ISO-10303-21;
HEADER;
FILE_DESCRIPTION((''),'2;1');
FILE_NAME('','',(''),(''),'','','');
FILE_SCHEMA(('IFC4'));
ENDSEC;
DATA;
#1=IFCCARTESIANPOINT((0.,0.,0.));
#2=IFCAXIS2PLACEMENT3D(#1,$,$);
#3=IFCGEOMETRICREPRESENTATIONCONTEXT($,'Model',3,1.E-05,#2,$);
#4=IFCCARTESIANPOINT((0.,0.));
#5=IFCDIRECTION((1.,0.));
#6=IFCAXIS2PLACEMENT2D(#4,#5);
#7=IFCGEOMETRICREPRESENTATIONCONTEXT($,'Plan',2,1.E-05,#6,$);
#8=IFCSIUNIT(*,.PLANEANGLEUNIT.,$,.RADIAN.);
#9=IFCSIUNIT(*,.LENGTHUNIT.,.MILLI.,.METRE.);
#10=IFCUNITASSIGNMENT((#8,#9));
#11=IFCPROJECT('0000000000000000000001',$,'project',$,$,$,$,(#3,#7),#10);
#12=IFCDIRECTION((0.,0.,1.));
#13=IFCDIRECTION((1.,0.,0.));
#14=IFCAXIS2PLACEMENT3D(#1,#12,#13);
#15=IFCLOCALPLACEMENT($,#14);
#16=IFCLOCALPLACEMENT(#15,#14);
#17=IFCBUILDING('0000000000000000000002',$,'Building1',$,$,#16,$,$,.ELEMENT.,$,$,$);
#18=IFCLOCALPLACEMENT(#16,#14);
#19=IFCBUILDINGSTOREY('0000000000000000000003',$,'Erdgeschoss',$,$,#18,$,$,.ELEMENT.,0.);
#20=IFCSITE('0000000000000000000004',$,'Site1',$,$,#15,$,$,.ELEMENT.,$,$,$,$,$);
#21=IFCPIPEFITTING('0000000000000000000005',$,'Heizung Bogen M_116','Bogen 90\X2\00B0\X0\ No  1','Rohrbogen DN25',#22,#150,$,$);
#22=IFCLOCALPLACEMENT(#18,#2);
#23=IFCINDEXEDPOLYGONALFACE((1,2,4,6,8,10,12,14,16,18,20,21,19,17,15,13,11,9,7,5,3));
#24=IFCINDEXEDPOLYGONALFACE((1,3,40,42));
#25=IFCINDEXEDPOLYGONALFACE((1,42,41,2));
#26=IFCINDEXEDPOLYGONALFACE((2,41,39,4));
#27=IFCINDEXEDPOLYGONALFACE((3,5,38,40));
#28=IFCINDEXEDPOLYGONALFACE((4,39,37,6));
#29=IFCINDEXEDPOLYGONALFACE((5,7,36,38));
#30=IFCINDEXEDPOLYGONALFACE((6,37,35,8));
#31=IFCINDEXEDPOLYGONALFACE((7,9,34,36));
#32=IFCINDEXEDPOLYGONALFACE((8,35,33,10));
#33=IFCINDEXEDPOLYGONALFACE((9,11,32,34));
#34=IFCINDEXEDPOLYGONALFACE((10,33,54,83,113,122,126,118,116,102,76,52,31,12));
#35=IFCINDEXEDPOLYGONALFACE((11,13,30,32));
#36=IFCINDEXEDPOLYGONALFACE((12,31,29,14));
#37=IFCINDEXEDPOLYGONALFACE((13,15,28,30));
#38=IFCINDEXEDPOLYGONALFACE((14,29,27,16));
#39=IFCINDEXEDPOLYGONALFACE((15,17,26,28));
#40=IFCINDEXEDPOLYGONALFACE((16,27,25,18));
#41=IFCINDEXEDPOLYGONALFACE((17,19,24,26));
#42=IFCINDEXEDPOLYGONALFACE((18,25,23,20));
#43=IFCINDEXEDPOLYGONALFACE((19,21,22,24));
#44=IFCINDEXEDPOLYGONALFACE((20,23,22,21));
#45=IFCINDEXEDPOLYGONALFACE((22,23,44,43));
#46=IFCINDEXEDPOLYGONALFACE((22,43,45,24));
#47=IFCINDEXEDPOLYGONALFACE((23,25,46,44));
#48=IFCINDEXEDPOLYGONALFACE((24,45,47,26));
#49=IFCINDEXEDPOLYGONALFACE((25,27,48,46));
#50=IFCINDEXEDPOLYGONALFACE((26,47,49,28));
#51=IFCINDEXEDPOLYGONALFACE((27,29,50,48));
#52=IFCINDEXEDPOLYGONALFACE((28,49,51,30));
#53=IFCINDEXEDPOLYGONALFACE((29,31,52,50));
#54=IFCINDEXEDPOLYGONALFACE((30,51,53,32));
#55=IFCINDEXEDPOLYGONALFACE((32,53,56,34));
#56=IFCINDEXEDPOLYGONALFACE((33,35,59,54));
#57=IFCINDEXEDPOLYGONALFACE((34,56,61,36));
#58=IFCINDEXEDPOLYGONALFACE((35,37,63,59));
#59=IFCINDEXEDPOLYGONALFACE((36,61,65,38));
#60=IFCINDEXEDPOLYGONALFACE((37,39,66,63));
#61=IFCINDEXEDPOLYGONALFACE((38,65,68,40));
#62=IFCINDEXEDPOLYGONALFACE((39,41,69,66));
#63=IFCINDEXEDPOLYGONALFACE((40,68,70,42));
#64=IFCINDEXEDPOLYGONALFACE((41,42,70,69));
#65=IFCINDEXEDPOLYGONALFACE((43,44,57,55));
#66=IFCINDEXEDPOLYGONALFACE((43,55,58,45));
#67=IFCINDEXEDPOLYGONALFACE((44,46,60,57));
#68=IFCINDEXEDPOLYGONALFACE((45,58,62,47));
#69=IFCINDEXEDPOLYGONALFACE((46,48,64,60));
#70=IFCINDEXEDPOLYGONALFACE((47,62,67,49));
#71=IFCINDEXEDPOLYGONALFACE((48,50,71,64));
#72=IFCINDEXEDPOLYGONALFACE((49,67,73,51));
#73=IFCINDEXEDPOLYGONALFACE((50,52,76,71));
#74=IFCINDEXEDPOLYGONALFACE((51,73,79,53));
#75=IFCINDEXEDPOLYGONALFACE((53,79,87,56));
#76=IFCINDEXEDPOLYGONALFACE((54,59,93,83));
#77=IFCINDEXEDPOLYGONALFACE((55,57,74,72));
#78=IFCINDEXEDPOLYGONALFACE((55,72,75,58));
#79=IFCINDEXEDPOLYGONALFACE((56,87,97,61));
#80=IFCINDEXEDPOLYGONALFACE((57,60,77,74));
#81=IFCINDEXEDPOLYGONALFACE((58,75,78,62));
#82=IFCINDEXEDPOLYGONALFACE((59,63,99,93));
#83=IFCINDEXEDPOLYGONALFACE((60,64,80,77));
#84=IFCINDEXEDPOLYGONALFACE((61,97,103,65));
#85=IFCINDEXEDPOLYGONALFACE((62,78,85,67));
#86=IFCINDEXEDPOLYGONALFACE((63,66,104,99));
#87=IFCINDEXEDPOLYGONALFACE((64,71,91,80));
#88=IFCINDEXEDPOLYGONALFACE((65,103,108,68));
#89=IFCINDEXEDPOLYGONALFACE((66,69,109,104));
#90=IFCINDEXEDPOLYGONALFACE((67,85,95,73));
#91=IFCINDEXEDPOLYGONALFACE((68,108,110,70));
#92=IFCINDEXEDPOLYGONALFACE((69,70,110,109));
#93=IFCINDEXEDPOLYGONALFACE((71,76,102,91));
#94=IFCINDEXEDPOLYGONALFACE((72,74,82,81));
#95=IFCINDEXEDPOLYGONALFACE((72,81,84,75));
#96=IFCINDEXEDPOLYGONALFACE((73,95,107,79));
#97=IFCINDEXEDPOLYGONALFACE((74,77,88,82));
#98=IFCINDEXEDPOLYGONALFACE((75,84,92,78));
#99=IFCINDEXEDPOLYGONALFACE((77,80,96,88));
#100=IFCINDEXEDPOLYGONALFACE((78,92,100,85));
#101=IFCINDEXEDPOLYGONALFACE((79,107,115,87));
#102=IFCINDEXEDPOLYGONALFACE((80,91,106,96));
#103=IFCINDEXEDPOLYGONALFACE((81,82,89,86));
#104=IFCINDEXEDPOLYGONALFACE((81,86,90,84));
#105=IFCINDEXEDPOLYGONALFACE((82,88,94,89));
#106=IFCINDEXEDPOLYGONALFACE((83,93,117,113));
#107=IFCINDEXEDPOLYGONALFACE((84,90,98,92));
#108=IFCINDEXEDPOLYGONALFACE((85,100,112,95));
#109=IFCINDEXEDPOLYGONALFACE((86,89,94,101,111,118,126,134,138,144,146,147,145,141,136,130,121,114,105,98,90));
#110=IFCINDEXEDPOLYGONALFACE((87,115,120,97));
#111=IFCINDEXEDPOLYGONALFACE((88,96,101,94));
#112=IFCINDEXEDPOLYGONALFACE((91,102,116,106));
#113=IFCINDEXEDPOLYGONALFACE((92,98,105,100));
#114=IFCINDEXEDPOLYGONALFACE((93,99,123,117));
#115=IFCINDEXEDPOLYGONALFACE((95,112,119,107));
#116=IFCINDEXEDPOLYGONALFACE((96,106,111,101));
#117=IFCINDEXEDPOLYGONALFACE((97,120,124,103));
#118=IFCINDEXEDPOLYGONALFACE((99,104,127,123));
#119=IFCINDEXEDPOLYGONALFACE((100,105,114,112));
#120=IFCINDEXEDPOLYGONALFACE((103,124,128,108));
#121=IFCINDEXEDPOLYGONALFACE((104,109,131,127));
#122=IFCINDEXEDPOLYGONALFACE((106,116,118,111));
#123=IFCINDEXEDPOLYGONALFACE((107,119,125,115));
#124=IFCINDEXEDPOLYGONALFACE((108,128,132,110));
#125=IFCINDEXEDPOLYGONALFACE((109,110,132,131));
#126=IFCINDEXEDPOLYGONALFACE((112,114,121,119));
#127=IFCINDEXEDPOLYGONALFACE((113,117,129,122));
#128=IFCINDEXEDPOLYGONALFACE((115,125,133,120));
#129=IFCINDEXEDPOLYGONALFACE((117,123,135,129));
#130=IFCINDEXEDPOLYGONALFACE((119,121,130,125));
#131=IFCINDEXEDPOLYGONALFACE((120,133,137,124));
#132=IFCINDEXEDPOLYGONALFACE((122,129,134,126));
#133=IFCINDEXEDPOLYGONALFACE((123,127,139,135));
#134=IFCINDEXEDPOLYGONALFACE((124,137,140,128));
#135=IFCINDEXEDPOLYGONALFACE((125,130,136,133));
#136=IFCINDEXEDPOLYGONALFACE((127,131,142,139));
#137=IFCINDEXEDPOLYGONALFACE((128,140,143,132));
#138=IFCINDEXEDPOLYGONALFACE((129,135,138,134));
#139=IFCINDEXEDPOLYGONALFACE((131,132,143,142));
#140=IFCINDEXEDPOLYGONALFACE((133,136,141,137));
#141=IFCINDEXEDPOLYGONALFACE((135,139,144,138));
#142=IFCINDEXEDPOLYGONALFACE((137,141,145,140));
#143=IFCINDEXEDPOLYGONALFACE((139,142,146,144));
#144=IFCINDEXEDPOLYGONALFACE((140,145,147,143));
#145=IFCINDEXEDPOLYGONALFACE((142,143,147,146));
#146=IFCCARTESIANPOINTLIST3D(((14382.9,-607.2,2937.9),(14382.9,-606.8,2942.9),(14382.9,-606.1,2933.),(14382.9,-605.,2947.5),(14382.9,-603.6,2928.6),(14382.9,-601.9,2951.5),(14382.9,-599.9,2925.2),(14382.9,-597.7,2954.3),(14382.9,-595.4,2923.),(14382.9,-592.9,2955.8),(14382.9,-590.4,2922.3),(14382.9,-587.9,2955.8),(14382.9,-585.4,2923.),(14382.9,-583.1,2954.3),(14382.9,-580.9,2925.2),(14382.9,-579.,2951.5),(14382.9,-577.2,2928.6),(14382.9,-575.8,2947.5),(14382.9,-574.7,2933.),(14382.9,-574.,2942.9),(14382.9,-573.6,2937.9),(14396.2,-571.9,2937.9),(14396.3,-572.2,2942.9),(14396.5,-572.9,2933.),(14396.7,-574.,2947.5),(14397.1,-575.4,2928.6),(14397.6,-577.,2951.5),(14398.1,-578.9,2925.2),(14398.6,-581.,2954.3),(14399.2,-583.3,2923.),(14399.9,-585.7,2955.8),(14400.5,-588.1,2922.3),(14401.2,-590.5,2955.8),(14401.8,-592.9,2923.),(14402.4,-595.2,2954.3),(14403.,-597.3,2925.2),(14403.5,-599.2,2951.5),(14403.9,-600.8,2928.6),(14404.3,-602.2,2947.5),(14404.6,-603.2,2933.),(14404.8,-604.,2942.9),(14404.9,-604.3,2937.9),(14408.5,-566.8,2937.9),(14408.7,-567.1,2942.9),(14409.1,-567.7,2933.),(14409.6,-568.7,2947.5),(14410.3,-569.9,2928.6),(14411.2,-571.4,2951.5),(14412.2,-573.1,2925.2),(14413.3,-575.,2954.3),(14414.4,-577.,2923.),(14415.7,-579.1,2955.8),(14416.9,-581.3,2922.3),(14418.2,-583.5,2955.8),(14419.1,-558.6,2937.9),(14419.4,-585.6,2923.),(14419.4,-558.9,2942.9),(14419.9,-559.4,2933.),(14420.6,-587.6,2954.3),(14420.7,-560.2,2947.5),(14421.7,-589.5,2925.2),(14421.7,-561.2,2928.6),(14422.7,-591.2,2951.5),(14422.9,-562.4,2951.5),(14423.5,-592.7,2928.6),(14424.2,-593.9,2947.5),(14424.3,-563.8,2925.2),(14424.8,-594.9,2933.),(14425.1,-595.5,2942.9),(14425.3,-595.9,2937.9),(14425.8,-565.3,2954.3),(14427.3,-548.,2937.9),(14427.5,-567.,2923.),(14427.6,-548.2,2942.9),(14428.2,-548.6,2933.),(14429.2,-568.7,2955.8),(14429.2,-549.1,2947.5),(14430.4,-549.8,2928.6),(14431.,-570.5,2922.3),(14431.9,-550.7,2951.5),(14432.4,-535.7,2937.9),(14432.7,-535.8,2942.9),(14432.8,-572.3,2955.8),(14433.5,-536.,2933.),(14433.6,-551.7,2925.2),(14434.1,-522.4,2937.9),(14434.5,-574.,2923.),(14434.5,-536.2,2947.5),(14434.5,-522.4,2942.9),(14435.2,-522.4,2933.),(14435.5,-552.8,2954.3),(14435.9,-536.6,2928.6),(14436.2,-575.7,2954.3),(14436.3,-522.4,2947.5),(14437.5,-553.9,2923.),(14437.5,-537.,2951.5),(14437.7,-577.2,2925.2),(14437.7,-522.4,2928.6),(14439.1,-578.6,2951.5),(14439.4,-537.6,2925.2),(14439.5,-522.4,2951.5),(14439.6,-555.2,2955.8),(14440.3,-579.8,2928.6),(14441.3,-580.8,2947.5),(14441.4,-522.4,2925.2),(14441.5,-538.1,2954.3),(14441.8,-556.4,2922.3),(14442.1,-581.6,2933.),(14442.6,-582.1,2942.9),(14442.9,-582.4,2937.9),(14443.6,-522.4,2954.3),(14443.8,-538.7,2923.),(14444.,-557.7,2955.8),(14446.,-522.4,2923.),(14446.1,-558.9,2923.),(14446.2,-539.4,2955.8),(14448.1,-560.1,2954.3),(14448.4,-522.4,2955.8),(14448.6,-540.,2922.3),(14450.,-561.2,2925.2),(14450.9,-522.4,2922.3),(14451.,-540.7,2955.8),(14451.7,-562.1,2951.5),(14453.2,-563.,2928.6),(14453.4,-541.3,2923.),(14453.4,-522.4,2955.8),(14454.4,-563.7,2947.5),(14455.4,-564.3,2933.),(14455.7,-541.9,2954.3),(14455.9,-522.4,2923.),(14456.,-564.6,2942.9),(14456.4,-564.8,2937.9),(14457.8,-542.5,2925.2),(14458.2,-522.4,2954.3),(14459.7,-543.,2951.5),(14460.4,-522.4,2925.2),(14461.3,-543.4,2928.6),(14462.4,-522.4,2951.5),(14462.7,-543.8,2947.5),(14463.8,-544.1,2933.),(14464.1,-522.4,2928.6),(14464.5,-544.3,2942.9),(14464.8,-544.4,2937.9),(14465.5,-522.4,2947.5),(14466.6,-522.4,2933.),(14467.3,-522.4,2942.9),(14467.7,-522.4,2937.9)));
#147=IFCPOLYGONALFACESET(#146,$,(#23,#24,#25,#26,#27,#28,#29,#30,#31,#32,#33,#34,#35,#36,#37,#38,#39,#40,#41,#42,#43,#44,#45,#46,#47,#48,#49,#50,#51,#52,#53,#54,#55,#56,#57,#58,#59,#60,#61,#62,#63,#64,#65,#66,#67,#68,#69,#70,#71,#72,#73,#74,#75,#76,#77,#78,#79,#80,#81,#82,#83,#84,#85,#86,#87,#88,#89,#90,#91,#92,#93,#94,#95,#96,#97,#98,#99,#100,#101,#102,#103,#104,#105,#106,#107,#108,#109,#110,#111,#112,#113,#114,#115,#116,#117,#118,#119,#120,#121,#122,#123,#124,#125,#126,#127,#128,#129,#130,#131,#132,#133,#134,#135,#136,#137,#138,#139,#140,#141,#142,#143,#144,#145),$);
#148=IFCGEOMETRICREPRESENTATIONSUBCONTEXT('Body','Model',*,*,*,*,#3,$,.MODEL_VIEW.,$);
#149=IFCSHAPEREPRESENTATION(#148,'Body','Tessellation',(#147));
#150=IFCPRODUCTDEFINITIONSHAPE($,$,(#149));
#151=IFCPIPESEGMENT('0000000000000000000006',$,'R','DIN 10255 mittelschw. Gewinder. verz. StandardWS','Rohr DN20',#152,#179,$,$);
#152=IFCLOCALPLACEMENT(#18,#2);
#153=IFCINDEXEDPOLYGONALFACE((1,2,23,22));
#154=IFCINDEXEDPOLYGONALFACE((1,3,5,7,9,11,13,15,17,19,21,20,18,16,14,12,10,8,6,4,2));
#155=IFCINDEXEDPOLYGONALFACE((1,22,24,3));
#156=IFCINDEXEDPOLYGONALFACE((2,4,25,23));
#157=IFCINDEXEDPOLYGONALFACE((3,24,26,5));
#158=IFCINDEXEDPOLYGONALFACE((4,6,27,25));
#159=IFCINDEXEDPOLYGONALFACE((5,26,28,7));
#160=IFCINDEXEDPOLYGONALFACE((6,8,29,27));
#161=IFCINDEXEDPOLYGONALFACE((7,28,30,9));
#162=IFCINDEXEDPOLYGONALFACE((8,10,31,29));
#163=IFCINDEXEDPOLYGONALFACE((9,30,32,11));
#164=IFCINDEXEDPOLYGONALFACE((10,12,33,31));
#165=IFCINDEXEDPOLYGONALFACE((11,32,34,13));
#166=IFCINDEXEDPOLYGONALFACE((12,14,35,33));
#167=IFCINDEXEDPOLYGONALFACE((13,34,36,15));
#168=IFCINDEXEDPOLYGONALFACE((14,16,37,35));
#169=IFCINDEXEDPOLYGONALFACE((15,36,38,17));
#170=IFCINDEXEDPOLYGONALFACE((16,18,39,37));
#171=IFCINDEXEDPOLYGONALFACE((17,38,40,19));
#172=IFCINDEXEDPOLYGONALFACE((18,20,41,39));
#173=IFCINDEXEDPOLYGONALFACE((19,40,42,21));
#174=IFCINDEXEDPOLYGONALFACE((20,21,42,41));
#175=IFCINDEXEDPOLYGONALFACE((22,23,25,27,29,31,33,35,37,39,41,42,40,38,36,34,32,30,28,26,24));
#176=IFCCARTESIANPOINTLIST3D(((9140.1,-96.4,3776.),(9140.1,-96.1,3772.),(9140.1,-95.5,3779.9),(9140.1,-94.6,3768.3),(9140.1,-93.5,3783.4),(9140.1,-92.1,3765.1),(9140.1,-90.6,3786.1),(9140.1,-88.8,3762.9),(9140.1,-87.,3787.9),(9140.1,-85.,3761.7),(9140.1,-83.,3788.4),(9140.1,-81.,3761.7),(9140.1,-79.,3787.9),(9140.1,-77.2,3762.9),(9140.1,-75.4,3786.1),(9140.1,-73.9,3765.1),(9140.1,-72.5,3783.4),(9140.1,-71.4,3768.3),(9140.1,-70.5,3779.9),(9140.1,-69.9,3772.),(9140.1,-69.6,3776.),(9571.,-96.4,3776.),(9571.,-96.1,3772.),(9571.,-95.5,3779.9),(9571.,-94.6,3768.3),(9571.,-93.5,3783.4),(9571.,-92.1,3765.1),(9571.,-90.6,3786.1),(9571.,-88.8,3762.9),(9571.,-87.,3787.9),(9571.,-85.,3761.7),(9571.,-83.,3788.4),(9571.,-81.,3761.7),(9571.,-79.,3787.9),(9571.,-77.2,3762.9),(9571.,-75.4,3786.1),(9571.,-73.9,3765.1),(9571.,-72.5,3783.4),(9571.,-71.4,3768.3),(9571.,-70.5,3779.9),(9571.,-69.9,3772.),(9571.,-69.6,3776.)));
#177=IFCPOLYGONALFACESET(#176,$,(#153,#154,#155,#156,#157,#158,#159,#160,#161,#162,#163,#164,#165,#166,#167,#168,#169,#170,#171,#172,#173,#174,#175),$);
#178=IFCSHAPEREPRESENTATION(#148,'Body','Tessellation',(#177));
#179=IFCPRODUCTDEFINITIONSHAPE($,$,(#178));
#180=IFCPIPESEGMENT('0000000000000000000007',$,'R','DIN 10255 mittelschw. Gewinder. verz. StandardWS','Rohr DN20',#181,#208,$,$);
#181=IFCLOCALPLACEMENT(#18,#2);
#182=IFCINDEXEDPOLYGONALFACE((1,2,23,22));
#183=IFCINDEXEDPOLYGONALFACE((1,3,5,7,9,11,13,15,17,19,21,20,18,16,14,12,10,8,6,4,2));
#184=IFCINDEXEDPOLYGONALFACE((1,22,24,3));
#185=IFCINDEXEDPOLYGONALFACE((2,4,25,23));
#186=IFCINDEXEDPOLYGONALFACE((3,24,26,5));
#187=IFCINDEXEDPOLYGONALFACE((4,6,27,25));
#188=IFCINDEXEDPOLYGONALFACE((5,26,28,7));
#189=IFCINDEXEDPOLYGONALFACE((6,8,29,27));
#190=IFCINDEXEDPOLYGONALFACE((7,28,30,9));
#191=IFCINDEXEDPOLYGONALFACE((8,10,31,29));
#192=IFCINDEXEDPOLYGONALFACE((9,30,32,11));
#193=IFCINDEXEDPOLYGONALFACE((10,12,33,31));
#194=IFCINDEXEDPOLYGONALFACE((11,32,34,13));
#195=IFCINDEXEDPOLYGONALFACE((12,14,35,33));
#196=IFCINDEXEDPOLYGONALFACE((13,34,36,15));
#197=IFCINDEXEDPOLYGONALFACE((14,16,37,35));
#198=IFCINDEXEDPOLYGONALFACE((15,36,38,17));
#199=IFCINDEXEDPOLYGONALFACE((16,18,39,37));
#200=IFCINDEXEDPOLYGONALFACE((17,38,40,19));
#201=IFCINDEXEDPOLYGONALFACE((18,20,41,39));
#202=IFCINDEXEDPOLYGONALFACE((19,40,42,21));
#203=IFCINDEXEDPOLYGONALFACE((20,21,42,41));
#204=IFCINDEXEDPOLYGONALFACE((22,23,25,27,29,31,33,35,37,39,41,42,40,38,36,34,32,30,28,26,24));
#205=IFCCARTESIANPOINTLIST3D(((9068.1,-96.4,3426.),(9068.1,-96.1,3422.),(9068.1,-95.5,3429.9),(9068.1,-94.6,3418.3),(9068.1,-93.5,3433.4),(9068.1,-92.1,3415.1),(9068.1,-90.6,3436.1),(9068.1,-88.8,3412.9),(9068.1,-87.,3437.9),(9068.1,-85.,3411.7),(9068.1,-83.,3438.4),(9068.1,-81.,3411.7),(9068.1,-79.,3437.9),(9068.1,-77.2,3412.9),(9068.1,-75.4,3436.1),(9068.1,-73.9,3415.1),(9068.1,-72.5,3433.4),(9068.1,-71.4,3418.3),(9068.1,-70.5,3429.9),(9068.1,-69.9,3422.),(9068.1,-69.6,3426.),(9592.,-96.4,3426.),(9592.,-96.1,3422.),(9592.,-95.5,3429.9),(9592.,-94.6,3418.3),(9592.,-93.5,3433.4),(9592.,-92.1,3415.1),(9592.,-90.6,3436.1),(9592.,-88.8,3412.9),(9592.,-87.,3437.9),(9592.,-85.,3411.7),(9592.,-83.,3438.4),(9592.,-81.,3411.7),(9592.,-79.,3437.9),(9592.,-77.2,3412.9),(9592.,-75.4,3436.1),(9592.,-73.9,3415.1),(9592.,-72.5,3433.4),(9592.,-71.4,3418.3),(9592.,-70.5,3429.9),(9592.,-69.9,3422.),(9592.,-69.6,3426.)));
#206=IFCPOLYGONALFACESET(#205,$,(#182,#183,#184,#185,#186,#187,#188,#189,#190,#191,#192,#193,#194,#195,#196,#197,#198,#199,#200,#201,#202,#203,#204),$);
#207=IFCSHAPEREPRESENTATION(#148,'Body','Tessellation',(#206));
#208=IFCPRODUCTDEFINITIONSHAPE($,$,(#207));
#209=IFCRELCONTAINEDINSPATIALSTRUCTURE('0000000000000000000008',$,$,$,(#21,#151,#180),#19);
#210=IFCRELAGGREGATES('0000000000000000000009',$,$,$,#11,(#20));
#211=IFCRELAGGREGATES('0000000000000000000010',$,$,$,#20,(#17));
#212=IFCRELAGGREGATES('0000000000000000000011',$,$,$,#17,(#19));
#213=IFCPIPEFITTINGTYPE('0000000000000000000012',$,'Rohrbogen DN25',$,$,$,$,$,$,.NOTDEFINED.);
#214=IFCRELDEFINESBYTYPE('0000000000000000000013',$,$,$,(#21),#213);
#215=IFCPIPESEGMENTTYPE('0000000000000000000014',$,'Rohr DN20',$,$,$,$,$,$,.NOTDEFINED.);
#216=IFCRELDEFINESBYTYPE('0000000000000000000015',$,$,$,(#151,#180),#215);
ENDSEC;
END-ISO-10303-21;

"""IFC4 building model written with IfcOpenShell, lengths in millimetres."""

from ifc_helpers import new_model, entity, si_unit, frame, origin, origin_with_axes, origin_2d_with_axis, place, context, subcontext, project, spatial, circle, extrude, source, transform, mapped, type_object, element, save


model = new_model("IFC4")

# Units and contexts
model_context = context("Model", 3, precision=1e-05, world=origin())
plan_context = context("Plan", 2, precision=1e-05, world=origin_2d_with_axis())
body_context = subcontext(model_context, "Body", "Model", "MODEL_VIEW")
ifc_project = project(units=[si_unit("PLANEANGLEUNIT", "RADIAN"), si_unit("LENGTHUNIT", "METRE", prefix="MILLI")], contexts=[model_context, plan_context])

# Site, building, storey
site_placement = place(None, origin_with_axes())
site = spatial("IfcSite", under=ifc_project, at=site_placement, Name="Site1", CompositionType="ELEMENT")
building_placement = place(site_placement, origin_with_axes())
building = spatial("IfcBuilding", under=site, at=building_placement, Name="Building1", CompositionType="ELEMENT")
storey_placement = place(building_placement, origin_with_axes())
storey = spatial("IfcBuildingStorey", under=building, at=storey_placement, Name="Erdgeschoss", CompositionType="ELEMENT", Elevation=0.0)

# Pipe fitting
pipe_fitting_type = type_object("IfcPipeFittingType", Name="Rohrbogen DN25", PredefinedType="NOTDEFINED")
shared_shape_1 = source(origin_with_axes(), body_context, "Body", "SolidModel", [
    entity("IfcRevolvedAreaSolid", entity("IfcCircleProfileDef", "AREA", None, entity("IfcAxis2Placement2D", entity("IfcCartesianPoint", [0.0, 0.0]), entity("IfcDirection", [1.0, 0.0])), 16.9), entity("IfcAxis2Placement3D", entity("IfcCartesianPoint", [-42.4, 25.6, 0.0]), entity("IfcDirection", [1.0, 0.0, 0.0]), entity("IfcDirection", [0.0, 0.0, 1.0])), entity("IfcAxis1Placement", entity("IfcCartesianPoint", [0.0, 68.0, 0.0]), entity("IfcDirection", [-1.0, 0.0, 0.0])), 1.570796),
])
pipe_fitting_1_placement = place(storey_placement, frame((14425.3, -564.8, 2939.1), z_axis=(0.0, 0.0, 1.0), x_axis=(1.0, 0.0, 0.0)))
element("IfcPipeFitting", 1, at=pipe_fitting_1_placement, inside=storey, type_object=pipe_fitting_type, Name="Heizung Bogen M_116", Description="Bogen 90° No  1", ObjectType="Rohrbogen DN25", context=body_context, shape_type="MappedRepresentation", body=[
    mapped(shared_shape_1, transform((0.0, 0.0, 0.0), x_axis=(1.0, 0.0, 0.0), y_axis=(0.0, -1.0, 0.0), z_axis=(0.0, 0.0, -1.0), scale=1.0)),
])

# Pipe segments
pipe_segment_type_1 = type_object("IfcPipeSegmentType", Name="Rohr DN20", PredefinedType="NOTDEFINED")
pipe_segment_1_placement = place(storey_placement, frame((9355.6, -83.2, 3775.0), z_axis=(0.0, 0.0, 1.0), x_axis=(1.0, 0.0, 0.0)))
element("IfcPipeSegment", 2, at=pipe_segment_1_placement, inside=storey, type_object=pipe_segment_type_1, Name="R", Description="DIN 10255 mittelschw. Gewinder. verz. StandardWS", ObjectType="Rohr DN20", context=body_context, shape_type="SolidModel", body=[
    extrude(circle(Radius=13.4, at=origin_2d_with_axis()), frame((215.5, 0.2, 0.0), z_axis=(-1.0, 0.0, 0.0), x_axis=(0.0, 0.0, 1.0)), (0.0, 0.0, 1.0), 430.9),
])
pipe_segment_2_placement = place(storey_placement, frame((9330.1, -83.2, 3425.0), z_axis=(0.0, 0.0, 1.0), x_axis=(1.0, 0.0, 0.0)))
element("IfcPipeSegment", 3, at=pipe_segment_2_placement, inside=storey, type_object=pipe_segment_type_1, Name="R", Description="DIN 10255 mittelschw. Gewinder. verz. StandardWS", ObjectType="Rohr DN20", context=body_context, shape_type="SolidModel", body=[
    extrude(circle(Radius=13.4, at=origin_2d_with_axis()), frame((262.0, 0.2, 0.0), z_axis=(-1.0, 0.0, 0.0), x_axis=(0.0, 0.0, 1.0)), (0.0, 0.0, 1.0), 523.9),
])

save(model, "model.ifc")
